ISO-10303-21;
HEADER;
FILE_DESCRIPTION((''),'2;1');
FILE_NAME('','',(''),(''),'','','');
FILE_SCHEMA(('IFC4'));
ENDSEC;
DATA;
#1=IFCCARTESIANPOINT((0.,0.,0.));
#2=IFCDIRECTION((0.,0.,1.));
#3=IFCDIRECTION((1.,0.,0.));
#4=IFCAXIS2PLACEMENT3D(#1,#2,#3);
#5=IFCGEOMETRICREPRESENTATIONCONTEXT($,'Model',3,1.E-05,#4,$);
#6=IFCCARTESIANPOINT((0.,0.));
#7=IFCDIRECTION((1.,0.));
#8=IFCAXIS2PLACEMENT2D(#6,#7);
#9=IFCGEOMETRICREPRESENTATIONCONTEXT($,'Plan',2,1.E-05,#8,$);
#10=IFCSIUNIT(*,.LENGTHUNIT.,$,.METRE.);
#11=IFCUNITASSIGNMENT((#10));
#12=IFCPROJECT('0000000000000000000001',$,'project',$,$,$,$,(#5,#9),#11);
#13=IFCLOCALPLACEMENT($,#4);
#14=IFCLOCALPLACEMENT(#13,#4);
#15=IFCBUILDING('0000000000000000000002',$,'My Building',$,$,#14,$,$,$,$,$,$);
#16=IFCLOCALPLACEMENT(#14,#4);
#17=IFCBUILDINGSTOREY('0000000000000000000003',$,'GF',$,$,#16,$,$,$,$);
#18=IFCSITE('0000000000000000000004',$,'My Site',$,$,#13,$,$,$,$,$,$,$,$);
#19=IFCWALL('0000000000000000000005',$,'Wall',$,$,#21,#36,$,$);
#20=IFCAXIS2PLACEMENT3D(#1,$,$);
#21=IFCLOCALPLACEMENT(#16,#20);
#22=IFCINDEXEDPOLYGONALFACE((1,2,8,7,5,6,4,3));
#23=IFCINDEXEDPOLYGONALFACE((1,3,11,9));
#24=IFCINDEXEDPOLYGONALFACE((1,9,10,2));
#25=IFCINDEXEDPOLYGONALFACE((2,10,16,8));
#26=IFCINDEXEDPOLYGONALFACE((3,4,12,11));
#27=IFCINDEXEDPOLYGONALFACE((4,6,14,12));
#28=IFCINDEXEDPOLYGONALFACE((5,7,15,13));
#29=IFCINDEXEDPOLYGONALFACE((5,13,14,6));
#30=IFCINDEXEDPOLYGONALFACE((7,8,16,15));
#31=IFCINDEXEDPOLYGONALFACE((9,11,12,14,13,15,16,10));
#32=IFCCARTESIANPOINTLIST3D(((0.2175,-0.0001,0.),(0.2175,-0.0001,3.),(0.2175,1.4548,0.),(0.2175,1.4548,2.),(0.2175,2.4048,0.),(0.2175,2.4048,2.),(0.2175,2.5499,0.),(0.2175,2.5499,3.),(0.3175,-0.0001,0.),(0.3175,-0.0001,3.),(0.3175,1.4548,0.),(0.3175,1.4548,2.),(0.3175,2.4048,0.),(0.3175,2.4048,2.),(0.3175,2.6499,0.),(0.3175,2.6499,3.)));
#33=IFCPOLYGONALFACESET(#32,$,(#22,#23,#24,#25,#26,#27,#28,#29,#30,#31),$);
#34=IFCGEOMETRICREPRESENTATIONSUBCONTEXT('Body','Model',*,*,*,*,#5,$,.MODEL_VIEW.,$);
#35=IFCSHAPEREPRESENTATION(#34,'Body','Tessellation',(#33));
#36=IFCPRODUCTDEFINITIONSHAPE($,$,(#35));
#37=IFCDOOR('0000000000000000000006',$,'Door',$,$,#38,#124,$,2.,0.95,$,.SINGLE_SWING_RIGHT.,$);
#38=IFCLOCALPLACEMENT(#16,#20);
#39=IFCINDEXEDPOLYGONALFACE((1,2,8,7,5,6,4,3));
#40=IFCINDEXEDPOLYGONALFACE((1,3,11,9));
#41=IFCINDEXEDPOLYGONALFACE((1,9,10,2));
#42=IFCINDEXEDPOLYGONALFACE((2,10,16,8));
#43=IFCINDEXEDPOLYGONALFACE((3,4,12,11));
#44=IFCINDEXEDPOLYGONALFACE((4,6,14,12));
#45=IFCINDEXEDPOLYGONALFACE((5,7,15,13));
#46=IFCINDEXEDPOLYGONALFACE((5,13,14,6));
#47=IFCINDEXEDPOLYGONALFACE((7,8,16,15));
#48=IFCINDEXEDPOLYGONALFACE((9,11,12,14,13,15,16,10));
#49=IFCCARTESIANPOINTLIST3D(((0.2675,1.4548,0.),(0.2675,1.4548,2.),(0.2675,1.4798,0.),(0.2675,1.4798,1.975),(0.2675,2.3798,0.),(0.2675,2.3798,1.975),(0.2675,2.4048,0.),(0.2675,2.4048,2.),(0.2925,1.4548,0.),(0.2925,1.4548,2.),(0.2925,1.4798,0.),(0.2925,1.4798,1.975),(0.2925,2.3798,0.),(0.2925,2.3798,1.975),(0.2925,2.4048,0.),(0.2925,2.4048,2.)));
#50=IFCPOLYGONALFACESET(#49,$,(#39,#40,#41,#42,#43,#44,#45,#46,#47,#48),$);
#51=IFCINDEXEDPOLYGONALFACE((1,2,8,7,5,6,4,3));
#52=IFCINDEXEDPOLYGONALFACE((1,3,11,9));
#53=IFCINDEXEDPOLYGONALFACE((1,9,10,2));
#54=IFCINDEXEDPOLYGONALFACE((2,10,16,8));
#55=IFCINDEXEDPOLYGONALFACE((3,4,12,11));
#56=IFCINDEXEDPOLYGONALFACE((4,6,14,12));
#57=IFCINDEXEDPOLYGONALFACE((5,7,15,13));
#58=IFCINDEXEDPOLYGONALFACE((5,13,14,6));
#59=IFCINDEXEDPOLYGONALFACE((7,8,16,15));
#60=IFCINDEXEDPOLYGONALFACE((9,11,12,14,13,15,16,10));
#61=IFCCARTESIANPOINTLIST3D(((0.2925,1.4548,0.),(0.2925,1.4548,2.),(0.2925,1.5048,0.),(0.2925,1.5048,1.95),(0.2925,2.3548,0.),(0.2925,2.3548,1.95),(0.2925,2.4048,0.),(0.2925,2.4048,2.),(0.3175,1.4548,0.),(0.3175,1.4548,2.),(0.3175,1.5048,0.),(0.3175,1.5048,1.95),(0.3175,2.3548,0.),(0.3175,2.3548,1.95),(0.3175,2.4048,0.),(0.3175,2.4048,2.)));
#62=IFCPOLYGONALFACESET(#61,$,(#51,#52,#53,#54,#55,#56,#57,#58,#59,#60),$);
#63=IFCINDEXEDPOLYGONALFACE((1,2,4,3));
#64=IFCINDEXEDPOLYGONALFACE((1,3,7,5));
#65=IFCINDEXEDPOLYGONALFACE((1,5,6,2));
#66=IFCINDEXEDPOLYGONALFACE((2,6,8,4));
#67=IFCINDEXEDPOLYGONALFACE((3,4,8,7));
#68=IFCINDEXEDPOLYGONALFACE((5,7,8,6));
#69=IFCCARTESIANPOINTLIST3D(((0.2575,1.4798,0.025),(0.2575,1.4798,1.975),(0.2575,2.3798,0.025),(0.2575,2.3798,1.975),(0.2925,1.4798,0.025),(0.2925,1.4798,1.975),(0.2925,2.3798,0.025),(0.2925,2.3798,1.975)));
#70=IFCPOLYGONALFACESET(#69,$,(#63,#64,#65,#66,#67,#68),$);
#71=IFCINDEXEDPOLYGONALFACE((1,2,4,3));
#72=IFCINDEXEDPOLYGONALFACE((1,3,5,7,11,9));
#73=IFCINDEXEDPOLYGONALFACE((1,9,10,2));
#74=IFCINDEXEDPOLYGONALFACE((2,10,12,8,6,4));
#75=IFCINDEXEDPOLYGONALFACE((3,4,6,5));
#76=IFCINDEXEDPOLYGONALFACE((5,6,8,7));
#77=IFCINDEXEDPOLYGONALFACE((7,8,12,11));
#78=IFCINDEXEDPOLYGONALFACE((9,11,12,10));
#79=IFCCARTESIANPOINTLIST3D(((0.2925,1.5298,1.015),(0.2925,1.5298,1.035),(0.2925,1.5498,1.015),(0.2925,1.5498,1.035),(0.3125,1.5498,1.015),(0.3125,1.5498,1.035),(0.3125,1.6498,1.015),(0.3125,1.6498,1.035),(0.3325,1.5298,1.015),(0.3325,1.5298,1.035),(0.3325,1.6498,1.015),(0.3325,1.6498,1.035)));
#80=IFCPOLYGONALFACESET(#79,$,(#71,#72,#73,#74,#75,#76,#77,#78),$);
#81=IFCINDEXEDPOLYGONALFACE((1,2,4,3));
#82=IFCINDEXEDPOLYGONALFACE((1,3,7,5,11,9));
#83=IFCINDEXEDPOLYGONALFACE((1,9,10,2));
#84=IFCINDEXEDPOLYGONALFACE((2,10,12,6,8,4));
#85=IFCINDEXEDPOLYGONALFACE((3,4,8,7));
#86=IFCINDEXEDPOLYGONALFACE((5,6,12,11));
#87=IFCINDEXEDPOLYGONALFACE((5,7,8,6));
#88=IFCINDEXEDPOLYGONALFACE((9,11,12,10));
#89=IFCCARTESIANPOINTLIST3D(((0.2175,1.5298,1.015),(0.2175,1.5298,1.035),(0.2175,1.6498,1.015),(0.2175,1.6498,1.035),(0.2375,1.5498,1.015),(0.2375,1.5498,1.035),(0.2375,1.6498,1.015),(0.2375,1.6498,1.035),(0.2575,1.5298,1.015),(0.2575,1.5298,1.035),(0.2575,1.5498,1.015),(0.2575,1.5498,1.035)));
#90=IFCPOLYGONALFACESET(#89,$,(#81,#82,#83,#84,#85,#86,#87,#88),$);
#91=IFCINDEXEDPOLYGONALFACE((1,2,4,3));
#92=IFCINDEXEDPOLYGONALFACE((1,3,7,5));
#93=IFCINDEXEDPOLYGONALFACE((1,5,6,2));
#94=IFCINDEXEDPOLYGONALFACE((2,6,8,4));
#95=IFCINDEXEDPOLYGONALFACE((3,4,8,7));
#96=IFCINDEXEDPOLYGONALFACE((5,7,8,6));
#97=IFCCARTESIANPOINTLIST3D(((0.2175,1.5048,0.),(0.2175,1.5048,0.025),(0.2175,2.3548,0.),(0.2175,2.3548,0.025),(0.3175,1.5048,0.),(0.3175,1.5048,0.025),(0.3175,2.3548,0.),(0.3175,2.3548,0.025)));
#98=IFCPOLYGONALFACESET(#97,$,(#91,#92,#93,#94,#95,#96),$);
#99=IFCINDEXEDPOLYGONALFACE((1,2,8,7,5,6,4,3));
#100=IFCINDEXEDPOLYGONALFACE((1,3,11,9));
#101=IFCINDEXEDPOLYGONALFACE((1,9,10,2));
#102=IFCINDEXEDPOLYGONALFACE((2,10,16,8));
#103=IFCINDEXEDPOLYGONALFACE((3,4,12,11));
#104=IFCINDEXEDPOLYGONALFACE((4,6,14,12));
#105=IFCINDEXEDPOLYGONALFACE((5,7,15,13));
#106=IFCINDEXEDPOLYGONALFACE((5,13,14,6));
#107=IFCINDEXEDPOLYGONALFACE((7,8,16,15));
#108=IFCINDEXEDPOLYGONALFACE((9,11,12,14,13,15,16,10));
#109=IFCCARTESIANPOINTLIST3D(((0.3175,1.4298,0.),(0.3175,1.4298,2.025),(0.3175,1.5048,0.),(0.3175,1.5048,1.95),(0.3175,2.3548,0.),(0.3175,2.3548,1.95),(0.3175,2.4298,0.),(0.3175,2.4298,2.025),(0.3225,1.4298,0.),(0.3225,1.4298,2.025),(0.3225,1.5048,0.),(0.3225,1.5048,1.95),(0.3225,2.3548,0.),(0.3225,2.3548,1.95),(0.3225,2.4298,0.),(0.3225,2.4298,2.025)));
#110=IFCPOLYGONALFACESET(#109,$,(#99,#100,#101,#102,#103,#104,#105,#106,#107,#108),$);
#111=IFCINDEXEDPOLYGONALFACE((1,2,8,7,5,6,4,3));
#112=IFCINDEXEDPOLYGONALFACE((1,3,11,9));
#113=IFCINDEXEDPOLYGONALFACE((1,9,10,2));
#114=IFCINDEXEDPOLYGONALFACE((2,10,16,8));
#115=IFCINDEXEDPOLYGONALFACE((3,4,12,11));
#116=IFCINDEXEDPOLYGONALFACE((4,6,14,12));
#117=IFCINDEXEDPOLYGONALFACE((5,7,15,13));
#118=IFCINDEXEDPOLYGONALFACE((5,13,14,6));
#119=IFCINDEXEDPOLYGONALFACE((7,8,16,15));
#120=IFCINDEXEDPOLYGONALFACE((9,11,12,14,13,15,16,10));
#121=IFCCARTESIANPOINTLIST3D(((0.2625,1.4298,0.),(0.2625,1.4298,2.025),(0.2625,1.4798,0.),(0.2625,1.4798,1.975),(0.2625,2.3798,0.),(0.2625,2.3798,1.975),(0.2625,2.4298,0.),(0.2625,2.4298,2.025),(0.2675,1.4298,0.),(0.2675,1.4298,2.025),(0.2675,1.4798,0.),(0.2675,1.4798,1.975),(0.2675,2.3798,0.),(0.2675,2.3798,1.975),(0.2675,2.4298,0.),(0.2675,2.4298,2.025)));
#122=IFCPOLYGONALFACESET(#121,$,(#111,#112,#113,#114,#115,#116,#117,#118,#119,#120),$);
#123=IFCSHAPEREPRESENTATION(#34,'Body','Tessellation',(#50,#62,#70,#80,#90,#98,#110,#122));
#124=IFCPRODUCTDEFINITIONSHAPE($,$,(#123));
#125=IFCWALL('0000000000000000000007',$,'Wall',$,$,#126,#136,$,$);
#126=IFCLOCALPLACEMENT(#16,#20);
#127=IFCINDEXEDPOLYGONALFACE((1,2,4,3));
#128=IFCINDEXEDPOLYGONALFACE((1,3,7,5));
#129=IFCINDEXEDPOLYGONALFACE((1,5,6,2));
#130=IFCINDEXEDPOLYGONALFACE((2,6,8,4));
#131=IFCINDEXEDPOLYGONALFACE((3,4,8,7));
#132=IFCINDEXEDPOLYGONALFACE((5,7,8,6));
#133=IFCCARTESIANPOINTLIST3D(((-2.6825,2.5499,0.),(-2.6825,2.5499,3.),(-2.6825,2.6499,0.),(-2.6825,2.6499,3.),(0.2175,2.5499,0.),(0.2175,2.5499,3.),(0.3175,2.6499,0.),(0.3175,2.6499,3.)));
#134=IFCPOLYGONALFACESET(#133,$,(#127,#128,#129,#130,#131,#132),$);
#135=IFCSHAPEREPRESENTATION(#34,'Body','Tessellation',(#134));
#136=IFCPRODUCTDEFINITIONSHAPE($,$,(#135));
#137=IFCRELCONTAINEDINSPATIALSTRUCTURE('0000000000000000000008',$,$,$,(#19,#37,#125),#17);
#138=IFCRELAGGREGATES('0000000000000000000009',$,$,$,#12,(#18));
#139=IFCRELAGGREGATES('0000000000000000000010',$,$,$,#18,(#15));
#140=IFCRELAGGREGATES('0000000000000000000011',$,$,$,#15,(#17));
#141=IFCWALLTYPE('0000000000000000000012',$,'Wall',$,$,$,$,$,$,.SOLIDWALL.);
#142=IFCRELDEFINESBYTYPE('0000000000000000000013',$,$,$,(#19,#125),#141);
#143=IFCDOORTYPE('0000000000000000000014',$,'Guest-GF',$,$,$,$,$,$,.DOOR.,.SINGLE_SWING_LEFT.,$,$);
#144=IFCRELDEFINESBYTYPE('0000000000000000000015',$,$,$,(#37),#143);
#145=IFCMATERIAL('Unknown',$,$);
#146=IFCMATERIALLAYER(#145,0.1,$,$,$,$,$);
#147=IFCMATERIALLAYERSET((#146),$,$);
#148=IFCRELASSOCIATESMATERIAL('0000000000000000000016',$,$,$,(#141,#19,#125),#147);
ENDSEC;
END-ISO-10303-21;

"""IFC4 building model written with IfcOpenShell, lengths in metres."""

from ifc_helpers import new_model, entity, si_unit, frame, origin_with_axes, origin_2d_with_axis, place, context, subcontext, project, spatial, line, indexed_curve, outline, extrude, shape, source, transform, mapped, material, layer, layer_set, layer_usage, type_object, type_shapes, element, fill, save


model = new_model("IFC4")

# Units and contexts
model_context = context("Model", 3, precision=1e-05, world=origin_with_axes())
plan_context = context("Plan", 2, precision=1e-05, world=origin_2d_with_axis())
body_context_1 = subcontext(model_context, "Body", "Model", "MODEL_VIEW")
body_context_2 = subcontext(plan_context, "Body", "Plan", "PLAN_VIEW")
ifc_project = project(units=[si_unit("LENGTHUNIT", "METRE")], contexts=[model_context, plan_context])

# Site, building, storey
site_placement = place(None, origin_with_axes())
site = spatial("IfcSite", under=ifc_project, at=site_placement, Name="My Site")
building_placement = place(site_placement, origin_with_axes())
building = spatial("IfcBuilding", under=site, at=building_placement, Name="My Building")
storey_placement = place(building_placement, origin_with_axes())
storey = spatial("IfcBuildingStorey", under=building, at=storey_placement, Name="GF")

# Shared definitions
ifc_material = material(Name="Unknown")

# Shared definitions
ifc_layer_1 = layer(ifc_material, 0.1)
ifc_layer_set_1 = layer_set([ifc_layer_1])
wall_type = type_object("IfcWallType", Name="Wall", PredefinedType="SOLIDWALL", material=ifc_layer_set_1)

# Wall, opening, door
ifc_layer_usage_1 = layer_usage(ifc_layer_set_1, "AXIS2", "POSITIVE", 0.0)
wall_1_placement = place(storey_placement, frame((0.3175, -0.0001, 0.0), z_axis=(0.0, 0.0, 1.0), x_axis=(0.0, 1.0, 0.0)))
wall_1 = element("IfcWall", 1, at=wall_1_placement, inside=storey, type_object=wall_type, material=ifc_layer_usage_1, Name="Wall", context=body_context_1, shape_type="SweptSolid", body=[
    extrude(outline(indexed_curve([(0.0, 0.0), (0.0, 0.1), (2.55, 0.1), (2.65, 0.0)], segments=[line(1, 2, 3, 4, 1)])), origin_with_axes(), (0.0, 0.0, 1.0), 3.0),
])
shared_shape_1 = source(origin_with_axes(), body_context_1, "Body", "SweptSolid", [
    extrude(outline(indexed_curve([(0.0, 0.0), (0.95, 0.0), (0.95, 2.0), (0.0, 2.0)], segments=[line(1, 2, 3, 4, 1)])), frame((0.0, -0.6, 0.0), z_axis=(0.0, -1.0, 0.0), x_axis=(1.0, 0.0, 0.0)), (0.0, 0.0, -1.0), 1.2),
])
opening_1_placement = place(wall_1_placement, frame((1.4549, 0.0, 0.0), z_axis=(0.0, 0.0, 1.0), x_axis=(1.0, 0.0, 0.0)))
opening_1 = element("IfcOpeningElement", 2, at=opening_1_placement, cuts=wall_1, PredefinedType="OPENING", context=body_context_1, shape_type="MappedRepresentation", body=[
    mapped(shared_shape_1, transform((0.0, 0.0, 0.0), x_axis=(1.0, 0.0, 0.0), y_axis=(0.0, 1.0, 0.0), z_axis=(0.0, 0.0, 1.0), scale=1.0)),
])
door_type_1 = type_object("IfcDoorType", Name="Guest-GF", OperationType="SINGLE_SWING_LEFT", PredefinedType="DOOR")
shared_shape_2 = source(origin_with_axes(), body_context_1, "Body", "SweptSolid", [
    extrude(outline(indexed_curve([(0.0, 0.0), (0.0, 2.0), (0.95, 2.0), (0.95, 0.0), (0.925, 0.0), (0.925, 1.975), (0.025, 1.975), (0.025, 0.0)], segments=[line(1, 2, 3, 4, 5, 6, 7, 8, 1)])), frame((0.0, 0.025, 0.0), z_axis=(0.0, -1.0, 0.0), x_axis=(1.0, 0.0, 0.0)), (0.0, 0.0, -1.0), 0.025),
    extrude(outline(indexed_curve([(0.0, 0.0), (0.0, 2.0), (0.95, 2.0), (0.95, 0.0), (0.9, 0.0), (0.9, 1.95), (0.05, 1.95), (0.05, 0.0)], segments=[line(1, 2, 3, 4, 5, 6, 7, 8, 1)])), frame((0.0, 0.0, 0.0), z_axis=(0.0, -1.0, 0.0), x_axis=(1.0, 0.0, 0.0)), (0.0, 0.0, -1.0), 0.025),
    extrude(outline(indexed_curve([(0.0, 0.0), (0.9, 0.0), (0.9, 0.035), (0.0, 0.035)], segments=[line(1, 2, 3, 4, 1)])), frame((0.025, 0.025, 0.025), z_axis=(0.0, 0.0, 1.0), x_axis=(1.0, 0.0, 0.0)), (0.0, 0.0, 1.0), 1.95),
    extrude(outline(indexed_curve([(0.0, 0.0), (0.0, -0.04), (0.12, -0.04), (0.12, -0.02), (0.02, -0.02), (0.02, 0.0)], segments=[line(1, 2, 3, 4, 5, 6, 1)])), frame((0.075, 0.025, 1.015), z_axis=(0.0, 0.0, 1.0), x_axis=(1.0, 0.0, 0.0)), (0.0, 0.0, 1.0), 0.02),
    extrude(outline(indexed_curve([(0.0, 0.0), (0.0, 0.04), (0.12, 0.04), (0.12, 0.02), (0.02, 0.02), (0.02, 0.0)], segments=[line(1, 2, 3, 4, 5, 6, 1)])), frame((0.075, 0.06, 1.015), z_axis=(0.0, 0.0, 1.0), x_axis=(1.0, 0.0, 0.0)), (0.0, 0.0, 1.0), 0.02),
    extrude(outline(indexed_curve([(0.0, 0.0), (0.85, 0.0), (0.85, 0.1), (0.0, 0.1)], segments=[line(1, 2, 3, 4, 1)])), frame((0.05, 0.0, 0.0), z_axis=(0.0, 0.0, 1.0), x_axis=(1.0, 0.0, 0.0)), (0.0, 0.0, 1.0), 0.025),
    extrude(outline(indexed_curve([(0.0, 0.0), (0.0, 2.025), (1.0, 2.025), (1.0, 0.0), (0.925, 0.0), (0.925, 1.95), (0.075, 1.95), (0.075, 0.0)], segments=[line(1, 2, 3, 4, 5, 6, 7, 8, 1)])), frame((-0.025, -0.005, 0.0), z_axis=(0.0, -1.0, 0.0), x_axis=(1.0, 0.0, 0.0)), (0.0, 0.0, -1.0), 0.005),
    extrude(outline(indexed_curve([(0.0, 0.0), (0.0, 2.025), (1.0, 2.025), (1.0, 0.0), (0.95, 0.0), (0.95, 1.975), (0.05, 1.975), (0.05, 0.0)], segments=[line(1, 2, 3, 4, 5, 6, 7, 8, 1)])), frame((-0.025, 0.05, 0.0), z_axis=(0.0, -1.0, 0.0), x_axis=(1.0, 0.0, 0.0)), (0.0, 0.0, -1.0), 0.005),
])
shared_shape_3 = source(origin_with_axes(), body_context_2, "Body", "Curve2D", [
    entity("IfcIndexedPolyCurve", entity("IfcCartesianPointList2D", [[0.0, 0.0], [0.0, 0.05], [0.025, 0.05], [0.025, 0.025], [0.05, 0.025], [0.05, 0.0]]), [entity("IfcLineIndex", [1, 2, 3, 4, 5, 6, 1])]),
    entity("IfcIndexedPolyCurve", entity("IfcCartesianPointList2D", [[0.95, 0.0], [0.95, 0.05], [0.925, 0.05], [0.925, 0.025], [0.9, 0.025], [0.9, 0.0]]), [entity("IfcLineIndex", [1, 2, 3, 4, 5, 6, 1])]),
    entity("IfcTrimmedCurve", entity("IfcEllipse", entity("IfcAxis2Placement2D", entity("IfcCartesianPoint", [0.89, 0.05]), entity("IfcDirection", [1.0, 0.0])), 0.865, 0.9), [entity("IfcCartesianPoint", [0.89, 0.95])], [entity("IfcCartesianPoint", [0.025, 0.05])], True, "CARTESIAN"),
    entity("IfcIndexedPolyCurve", entity("IfcCartesianPointList2D", [[0.925, 0.05], [0.89, 0.05], [0.89, 0.95], [0.925, 0.95]]), [entity("IfcLineIndex", [1, 2, 3, 4, 1])]),
])
type_shapes(door_type_1, [shared_shape_2, shared_shape_3])
door_1_placement = place(opening_1_placement, frame((0.0, 0.0, 0.0), z_axis=(0.0, 0.0, 1.0), x_axis=(1.0, 0.0, 0.0)))
door_1 = element("IfcDoor", 3, at=door_1_placement, inside=storey, type_object=door_type_1, Name="Door", OperationType="SINGLE_SWING_RIGHT", OverallHeight=2.0, OverallWidth=0.95, shapes=[
    shape(body_context_1, "Body", "MappedRepresentation", [mapped(shared_shape_2, transform((0.0, 0.0, 0.0), x_axis=(1.0, 0.0, 0.0), y_axis=(0.0, 1.0, 0.0), z_axis=(0.0, 0.0, 1.0), scale=1.0))]),
    shape(body_context_2, "Body", "MappedRepresentation", [mapped(shared_shape_3, transform((0.0, 0.0, 0.0), x_axis=(1.0, 0.0, 0.0), y_axis=(0.0, 1.0, 0.0), z_axis=(0.0, 0.0, 1.0), scale=1.0))]),
])
fill(opening_1, door_1)

# Wall
ifc_layer_usage_2 = layer_usage(ifc_layer_set_1, "AXIS2", "POSITIVE", 0.0)
wall_2_placement = place(storey_placement, frame((0.3175, 2.6499, 0.0), z_axis=(0.0, 0.0, 1.0), x_axis=(-1.0, 0.0, 0.0)))
element("IfcWall", 4, at=wall_2_placement, inside=storey, type_object=wall_type, material=ifc_layer_usage_2, Name="Wall", context=body_context_1, shape_type="SweptSolid", body=[
    extrude(outline(indexed_curve([(0.0, 0.0), (0.1, 0.1), (3.0, 0.1), (3.0, 0.0)], segments=[line(1, 2, 3, 4, 1)])), origin_with_axes(), (0.0, 0.0, 1.0), 3.0),
])

save(model, "model.ifc")
